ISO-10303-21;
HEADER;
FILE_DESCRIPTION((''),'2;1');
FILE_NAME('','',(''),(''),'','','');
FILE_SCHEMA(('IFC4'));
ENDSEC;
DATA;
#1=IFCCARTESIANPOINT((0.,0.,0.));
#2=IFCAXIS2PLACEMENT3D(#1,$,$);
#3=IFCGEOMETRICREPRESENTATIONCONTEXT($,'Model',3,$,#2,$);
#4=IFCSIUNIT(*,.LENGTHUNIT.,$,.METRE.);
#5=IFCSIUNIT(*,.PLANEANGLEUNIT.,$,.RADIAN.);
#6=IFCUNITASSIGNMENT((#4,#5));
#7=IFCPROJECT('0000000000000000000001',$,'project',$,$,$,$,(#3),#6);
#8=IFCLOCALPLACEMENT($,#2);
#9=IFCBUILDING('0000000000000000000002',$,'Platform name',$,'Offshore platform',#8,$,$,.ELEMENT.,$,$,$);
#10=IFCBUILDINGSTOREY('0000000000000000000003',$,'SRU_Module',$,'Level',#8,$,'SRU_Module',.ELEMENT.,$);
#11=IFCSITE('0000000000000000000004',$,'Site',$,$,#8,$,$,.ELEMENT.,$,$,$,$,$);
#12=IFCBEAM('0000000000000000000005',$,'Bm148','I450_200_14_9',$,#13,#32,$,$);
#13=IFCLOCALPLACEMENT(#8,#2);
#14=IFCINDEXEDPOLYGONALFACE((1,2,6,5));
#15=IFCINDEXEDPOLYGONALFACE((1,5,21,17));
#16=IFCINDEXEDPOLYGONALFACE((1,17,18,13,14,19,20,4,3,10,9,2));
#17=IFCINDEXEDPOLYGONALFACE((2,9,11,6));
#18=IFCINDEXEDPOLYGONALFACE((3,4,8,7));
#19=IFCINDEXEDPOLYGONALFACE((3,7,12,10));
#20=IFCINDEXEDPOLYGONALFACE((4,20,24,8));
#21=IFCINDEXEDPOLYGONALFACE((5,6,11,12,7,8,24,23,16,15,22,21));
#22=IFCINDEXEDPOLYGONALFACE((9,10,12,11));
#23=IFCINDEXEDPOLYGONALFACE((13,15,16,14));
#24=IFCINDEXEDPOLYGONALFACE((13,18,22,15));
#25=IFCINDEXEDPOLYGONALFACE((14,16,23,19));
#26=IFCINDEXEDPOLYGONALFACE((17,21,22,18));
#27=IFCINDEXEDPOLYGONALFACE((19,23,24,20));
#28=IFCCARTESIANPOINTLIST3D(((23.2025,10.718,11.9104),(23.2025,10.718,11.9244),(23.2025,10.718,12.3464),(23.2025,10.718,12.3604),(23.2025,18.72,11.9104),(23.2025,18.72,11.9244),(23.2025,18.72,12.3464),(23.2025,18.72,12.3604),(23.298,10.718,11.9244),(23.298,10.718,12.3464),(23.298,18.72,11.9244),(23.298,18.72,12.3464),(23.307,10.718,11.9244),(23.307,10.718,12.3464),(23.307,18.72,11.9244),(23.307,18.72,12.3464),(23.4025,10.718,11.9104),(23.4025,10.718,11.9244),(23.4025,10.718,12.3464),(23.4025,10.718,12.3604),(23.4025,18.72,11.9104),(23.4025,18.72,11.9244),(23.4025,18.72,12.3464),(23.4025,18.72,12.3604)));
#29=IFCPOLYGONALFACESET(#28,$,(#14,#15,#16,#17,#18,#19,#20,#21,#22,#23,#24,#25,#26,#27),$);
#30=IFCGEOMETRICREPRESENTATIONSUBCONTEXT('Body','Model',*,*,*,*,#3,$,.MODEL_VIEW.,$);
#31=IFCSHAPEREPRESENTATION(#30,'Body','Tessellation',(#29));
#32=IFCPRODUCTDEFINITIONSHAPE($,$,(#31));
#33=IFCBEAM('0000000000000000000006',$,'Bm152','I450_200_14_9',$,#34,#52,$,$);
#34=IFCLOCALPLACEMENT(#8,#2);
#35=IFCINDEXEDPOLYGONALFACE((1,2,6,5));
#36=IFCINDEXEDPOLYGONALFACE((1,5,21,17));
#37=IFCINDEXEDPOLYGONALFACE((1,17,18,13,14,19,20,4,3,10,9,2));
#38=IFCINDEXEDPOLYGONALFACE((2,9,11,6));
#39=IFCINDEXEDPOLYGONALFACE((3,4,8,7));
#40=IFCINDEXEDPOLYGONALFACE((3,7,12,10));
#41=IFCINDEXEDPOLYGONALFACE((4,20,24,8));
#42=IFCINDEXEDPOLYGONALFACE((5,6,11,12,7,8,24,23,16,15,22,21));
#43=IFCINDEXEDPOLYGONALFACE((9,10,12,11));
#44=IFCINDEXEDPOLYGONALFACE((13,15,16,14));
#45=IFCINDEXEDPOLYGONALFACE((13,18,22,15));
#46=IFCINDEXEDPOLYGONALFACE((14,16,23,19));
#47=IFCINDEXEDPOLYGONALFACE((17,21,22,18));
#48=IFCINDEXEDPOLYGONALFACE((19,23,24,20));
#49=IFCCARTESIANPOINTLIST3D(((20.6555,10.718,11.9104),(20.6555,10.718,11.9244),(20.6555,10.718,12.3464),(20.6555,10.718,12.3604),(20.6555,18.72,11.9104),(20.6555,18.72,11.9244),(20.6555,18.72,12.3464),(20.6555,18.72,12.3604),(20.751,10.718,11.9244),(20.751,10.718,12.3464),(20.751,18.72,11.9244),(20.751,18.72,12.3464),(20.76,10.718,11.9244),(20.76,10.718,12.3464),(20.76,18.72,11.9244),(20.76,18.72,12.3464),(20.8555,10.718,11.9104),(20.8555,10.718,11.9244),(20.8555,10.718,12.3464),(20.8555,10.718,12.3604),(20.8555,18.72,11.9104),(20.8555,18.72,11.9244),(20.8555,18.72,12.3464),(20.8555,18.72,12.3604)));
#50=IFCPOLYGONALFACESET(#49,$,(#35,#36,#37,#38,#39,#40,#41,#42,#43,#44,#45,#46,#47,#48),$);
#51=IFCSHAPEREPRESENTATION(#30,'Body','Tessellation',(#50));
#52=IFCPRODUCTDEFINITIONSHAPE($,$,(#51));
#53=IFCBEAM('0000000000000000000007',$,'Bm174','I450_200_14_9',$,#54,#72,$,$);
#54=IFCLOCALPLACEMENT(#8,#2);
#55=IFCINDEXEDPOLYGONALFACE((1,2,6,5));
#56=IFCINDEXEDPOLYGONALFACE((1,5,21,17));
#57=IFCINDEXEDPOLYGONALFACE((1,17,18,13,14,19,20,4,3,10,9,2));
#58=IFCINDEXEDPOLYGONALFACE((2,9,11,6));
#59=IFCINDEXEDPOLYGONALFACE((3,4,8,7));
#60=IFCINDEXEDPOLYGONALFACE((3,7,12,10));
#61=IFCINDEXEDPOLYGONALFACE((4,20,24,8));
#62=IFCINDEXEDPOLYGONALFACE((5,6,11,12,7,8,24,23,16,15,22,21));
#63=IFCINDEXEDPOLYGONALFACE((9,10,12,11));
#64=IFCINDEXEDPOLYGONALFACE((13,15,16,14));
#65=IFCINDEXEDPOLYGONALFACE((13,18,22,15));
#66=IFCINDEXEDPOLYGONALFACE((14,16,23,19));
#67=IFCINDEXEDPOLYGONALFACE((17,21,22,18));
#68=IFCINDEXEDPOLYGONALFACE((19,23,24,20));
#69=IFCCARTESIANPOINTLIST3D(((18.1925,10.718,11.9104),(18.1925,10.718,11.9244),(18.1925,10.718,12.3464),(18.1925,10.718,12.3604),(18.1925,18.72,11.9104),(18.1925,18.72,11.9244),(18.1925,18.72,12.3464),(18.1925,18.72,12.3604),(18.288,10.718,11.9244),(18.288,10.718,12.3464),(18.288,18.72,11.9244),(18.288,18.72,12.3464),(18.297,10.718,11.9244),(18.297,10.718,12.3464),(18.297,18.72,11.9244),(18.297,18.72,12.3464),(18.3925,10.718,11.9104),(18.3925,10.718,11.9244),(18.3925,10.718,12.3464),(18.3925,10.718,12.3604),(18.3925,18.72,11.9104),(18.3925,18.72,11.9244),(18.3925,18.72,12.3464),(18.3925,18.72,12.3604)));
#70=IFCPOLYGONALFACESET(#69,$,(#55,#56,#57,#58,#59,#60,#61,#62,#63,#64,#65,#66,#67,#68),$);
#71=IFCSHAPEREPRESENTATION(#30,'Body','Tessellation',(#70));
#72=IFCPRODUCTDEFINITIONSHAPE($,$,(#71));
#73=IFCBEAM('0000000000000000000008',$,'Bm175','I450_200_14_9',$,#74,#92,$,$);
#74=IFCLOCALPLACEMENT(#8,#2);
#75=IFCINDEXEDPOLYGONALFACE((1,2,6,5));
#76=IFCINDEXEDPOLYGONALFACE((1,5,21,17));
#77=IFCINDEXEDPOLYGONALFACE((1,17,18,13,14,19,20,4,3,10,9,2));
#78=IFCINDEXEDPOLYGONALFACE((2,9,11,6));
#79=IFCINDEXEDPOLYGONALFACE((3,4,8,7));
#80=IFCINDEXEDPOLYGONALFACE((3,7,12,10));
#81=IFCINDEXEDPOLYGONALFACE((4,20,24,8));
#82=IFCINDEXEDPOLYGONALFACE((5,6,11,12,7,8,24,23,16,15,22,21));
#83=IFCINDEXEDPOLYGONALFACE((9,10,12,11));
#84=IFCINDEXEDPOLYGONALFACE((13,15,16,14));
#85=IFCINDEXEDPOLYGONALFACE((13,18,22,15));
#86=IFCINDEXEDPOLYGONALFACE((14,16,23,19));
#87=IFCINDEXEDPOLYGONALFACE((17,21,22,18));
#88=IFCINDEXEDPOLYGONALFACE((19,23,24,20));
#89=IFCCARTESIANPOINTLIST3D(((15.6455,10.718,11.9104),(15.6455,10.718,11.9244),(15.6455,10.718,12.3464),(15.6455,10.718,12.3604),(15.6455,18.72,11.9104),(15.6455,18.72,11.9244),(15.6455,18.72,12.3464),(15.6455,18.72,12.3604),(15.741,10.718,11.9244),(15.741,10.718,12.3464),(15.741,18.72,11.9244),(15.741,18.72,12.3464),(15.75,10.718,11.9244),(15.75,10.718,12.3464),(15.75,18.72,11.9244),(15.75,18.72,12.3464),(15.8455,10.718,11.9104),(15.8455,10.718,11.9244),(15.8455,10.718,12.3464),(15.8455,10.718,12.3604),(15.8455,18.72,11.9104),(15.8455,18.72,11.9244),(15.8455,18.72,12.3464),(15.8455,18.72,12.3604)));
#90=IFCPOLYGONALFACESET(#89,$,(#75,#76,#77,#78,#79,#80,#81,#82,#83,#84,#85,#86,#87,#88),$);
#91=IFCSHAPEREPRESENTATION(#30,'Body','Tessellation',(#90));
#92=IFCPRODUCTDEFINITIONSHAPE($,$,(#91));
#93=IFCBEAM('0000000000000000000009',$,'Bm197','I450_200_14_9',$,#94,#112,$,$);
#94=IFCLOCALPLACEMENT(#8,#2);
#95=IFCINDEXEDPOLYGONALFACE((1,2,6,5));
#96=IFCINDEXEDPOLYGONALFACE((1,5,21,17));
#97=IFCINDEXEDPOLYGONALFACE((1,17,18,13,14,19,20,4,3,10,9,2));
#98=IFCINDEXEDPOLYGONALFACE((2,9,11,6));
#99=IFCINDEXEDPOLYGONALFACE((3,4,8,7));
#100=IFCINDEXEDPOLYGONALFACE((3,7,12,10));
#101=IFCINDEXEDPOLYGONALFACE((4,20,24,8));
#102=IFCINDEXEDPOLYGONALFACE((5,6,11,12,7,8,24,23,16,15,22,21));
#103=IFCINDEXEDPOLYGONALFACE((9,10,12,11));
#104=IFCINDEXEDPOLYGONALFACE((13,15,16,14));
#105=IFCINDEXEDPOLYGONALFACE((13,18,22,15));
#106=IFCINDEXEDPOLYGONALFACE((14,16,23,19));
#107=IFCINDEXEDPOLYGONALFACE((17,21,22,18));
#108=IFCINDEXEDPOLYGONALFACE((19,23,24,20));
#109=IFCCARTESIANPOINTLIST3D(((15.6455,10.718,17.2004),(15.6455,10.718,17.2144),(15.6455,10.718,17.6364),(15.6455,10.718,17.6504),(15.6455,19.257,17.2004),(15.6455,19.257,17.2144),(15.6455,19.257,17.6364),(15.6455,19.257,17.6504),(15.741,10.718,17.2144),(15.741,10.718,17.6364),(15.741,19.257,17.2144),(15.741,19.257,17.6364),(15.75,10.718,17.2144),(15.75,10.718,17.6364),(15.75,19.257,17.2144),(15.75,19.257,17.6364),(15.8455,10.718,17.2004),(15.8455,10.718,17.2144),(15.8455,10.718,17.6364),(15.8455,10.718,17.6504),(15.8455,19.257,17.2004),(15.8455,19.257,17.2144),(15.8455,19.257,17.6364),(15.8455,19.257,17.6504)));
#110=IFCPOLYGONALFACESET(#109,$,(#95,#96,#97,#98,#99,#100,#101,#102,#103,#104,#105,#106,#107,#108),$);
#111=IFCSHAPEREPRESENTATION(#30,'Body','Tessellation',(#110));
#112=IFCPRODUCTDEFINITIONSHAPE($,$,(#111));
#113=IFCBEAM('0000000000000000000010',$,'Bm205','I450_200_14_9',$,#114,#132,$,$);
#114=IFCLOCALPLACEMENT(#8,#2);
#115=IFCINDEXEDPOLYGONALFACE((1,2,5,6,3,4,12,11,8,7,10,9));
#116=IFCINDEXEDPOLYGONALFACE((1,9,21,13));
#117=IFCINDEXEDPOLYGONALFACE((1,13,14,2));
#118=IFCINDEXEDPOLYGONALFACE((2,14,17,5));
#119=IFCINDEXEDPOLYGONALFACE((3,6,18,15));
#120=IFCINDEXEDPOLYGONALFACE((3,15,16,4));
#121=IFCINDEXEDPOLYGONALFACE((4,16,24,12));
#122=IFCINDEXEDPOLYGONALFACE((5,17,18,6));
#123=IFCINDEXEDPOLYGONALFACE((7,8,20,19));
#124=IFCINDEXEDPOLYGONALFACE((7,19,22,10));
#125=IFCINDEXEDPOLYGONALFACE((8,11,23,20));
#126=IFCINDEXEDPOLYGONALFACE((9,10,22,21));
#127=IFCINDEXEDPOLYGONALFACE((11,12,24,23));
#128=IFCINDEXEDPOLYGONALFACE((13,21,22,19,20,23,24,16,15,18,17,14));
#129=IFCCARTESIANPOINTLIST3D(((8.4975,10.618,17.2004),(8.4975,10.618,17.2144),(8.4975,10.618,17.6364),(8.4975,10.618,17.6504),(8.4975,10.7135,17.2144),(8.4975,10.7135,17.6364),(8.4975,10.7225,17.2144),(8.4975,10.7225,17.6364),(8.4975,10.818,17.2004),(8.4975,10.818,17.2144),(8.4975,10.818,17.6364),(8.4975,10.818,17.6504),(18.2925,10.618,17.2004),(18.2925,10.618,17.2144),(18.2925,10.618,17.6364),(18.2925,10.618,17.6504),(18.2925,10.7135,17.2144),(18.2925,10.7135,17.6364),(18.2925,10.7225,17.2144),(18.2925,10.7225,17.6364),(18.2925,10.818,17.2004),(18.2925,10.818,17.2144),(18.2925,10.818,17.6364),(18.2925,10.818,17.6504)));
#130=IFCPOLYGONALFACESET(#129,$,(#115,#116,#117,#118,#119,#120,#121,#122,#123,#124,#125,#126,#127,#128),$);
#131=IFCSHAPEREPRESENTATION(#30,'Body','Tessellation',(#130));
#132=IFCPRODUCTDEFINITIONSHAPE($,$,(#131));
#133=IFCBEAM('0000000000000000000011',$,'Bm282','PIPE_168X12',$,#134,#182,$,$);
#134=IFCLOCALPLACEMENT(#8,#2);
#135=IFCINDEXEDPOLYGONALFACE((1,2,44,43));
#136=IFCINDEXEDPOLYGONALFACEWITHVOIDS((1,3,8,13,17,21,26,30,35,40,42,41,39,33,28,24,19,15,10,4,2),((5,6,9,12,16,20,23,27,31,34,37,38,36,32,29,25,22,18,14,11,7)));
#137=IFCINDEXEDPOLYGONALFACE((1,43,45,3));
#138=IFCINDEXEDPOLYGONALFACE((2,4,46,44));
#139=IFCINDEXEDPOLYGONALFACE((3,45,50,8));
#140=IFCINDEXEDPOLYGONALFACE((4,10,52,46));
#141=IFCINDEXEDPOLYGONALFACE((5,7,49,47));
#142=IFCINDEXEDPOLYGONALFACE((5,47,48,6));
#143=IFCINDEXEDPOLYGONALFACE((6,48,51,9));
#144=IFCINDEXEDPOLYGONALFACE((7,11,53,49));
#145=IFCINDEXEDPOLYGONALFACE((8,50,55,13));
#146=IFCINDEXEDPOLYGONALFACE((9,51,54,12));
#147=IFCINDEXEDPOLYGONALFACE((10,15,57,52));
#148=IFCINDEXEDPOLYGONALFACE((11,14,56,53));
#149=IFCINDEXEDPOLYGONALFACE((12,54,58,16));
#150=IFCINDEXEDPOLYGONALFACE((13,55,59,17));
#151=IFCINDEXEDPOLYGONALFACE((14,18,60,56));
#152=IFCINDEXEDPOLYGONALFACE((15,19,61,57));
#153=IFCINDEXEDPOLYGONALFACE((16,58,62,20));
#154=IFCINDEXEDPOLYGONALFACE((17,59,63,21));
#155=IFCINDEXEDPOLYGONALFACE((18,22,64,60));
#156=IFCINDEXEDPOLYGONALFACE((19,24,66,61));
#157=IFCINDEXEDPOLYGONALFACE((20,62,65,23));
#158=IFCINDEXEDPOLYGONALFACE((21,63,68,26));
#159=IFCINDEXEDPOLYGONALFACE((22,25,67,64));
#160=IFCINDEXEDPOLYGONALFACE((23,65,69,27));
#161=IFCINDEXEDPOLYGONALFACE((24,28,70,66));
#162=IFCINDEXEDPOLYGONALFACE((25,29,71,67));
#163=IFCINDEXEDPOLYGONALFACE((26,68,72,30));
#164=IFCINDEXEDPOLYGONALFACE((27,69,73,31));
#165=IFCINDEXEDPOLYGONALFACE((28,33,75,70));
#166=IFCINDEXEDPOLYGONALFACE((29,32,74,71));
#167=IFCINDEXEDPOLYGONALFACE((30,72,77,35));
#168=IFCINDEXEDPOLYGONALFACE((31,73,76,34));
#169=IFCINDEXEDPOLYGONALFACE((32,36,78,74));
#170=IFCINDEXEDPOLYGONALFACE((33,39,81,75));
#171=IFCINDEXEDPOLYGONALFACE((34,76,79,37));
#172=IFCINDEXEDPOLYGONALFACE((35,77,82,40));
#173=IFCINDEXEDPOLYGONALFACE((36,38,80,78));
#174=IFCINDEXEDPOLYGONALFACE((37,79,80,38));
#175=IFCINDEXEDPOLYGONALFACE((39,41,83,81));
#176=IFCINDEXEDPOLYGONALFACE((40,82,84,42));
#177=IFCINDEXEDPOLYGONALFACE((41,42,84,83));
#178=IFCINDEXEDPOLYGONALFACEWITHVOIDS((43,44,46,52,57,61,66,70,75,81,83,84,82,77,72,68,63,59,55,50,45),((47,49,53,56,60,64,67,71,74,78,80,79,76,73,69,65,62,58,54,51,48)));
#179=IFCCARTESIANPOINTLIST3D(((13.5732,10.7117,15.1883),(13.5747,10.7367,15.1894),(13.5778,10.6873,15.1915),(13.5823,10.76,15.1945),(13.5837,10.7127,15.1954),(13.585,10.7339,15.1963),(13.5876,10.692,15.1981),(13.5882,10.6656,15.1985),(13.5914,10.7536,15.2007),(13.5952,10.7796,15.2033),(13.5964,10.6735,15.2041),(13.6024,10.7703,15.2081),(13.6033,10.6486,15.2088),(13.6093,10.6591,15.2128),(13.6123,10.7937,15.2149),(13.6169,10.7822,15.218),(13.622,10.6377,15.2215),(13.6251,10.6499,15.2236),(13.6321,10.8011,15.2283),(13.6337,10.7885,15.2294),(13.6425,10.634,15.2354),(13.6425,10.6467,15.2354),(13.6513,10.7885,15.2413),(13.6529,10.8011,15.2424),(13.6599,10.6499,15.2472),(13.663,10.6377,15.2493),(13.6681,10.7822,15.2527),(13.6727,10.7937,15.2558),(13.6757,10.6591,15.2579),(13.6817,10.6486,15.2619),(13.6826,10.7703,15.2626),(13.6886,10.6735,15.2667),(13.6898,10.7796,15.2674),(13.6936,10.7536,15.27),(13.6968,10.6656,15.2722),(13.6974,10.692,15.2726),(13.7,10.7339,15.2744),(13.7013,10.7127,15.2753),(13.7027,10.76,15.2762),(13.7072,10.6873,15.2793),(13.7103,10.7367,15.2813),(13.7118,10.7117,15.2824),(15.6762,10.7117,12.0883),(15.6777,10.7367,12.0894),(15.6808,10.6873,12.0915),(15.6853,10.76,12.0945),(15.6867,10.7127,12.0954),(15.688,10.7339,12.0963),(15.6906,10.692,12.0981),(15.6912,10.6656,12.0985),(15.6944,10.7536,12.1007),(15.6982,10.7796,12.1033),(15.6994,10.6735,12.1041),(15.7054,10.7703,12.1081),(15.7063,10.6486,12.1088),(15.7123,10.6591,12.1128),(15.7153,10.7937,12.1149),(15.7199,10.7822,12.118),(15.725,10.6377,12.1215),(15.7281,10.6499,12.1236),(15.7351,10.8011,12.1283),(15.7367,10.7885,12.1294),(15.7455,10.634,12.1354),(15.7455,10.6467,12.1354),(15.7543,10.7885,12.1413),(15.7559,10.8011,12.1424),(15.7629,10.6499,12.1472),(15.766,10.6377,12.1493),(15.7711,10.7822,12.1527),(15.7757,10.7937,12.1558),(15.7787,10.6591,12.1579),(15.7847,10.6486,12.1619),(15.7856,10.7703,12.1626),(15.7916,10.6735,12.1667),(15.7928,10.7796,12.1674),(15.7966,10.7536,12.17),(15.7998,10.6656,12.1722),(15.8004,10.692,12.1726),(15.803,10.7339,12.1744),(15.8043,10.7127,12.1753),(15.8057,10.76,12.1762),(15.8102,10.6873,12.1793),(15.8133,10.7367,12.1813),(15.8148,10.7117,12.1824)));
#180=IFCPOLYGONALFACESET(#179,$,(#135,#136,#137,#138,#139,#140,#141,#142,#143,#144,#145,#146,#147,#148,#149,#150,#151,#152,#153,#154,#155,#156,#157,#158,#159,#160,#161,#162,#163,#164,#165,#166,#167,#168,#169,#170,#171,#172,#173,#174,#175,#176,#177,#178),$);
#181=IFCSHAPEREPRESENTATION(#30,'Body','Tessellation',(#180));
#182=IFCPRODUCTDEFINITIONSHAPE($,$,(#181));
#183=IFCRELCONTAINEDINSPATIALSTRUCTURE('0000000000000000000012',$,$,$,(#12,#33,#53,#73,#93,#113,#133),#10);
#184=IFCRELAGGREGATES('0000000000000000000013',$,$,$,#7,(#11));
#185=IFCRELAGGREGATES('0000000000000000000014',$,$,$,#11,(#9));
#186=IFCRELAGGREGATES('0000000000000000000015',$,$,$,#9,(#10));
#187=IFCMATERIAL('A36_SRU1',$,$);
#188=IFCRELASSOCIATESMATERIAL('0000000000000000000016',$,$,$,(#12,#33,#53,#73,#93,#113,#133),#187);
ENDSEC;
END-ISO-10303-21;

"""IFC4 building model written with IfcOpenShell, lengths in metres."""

from ifc_helpers import new_model, si_unit, frame, origin, origin_2d, place, context, subcontext, project, spatial, hollow_circle, i_section, extrude, source, transform, mapped, material, element, save


model = new_model("IFC4")

# Units and contexts
model_context = context("Model", 3, world=origin())
body_context = subcontext(model_context, "Body", "Model", "MODEL_VIEW")
ifc_project = project(units=[si_unit("LENGTHUNIT", "METRE"), si_unit("PLANEANGLEUNIT", "RADIAN")], contexts=[model_context])

# Site, building, storey
placement_1 = place(None, origin())
site = spatial("IfcSite", under=ifc_project, at=placement_1, Name="Site", CompositionType="ELEMENT")
building = spatial("IfcBuilding", under=site, at=placement_1, Name="Platform name", ObjectType="Offshore platform", CompositionType="ELEMENT")
storey = spatial("IfcBuildingStorey", under=building, at=placement_1, Name="SRU_Module", ObjectType="Level", LongName="SRU_Module", CompositionType="ELEMENT")

# Beams
ifc_material = material(Name="A36_SRU1")
shared_shape_1 = source(origin(), body_context, "Body", "SweptSolid", [
    extrude(i_section(OverallWidth=0.2, OverallDepth=0.45, WebThickness=0.009, FlangeThickness=0.014, FilletRadius=0.0, at=origin_2d()), frame((0.0, 0.0, 0.0), z_axis=(0.0, 1.0, 0.0), x_axis=(-1.0, 0.0, 0.0)), (0.0, 0.0, 1.0), 8.002),
])
placement_2 = place(None, origin())
placement_3 = place(placement_2, origin())
placement_4 = place(placement_3, origin())
beam_1_placement = place(placement_4, frame((23.3025, 10.718, 12.1354)))
element("IfcBeam", 1, at=beam_1_placement, inside=storey, material=ifc_material, Name="Bm148", Description="I450_200_14_9", context=body_context, shape_type="MappedRepresentation", body=[
    mapped(shared_shape_1, transform((0.0, 0.0, 0.0), scale=1.0)),
])
shared_shape_2 = source(origin(), body_context, "Body", "SweptSolid", [
    extrude(i_section(OverallWidth=0.2, OverallDepth=0.45, WebThickness=0.009, FlangeThickness=0.014, FilletRadius=0.0, at=origin_2d()), frame((0.0, 0.0, 0.0), z_axis=(0.0, 1.0, 0.0), x_axis=(-1.0, 0.0, 0.0)), (0.0, 0.0, 1.0), 8.002),
])
placement_5 = place(None, origin())
placement_6 = place(placement_5, origin())
placement_7 = place(placement_6, origin())
beam_2_placement = place(placement_7, frame((20.7555, 10.718, 12.1354)))
element("IfcBeam", 2, at=beam_2_placement, inside=storey, material=ifc_material, Name="Bm152", Description="I450_200_14_9", context=body_context, shape_type="MappedRepresentation", body=[
    mapped(shared_shape_2, transform((0.0, 0.0, 0.0), scale=1.0)),
])
shared_shape_3 = source(origin(), body_context, "Body", "SweptSolid", [
    extrude(i_section(OverallWidth=0.2, OverallDepth=0.45, WebThickness=0.009, FlangeThickness=0.014, FilletRadius=0.0, at=origin_2d()), frame((0.0, 0.0, 0.0), z_axis=(0.0, 1.0, 0.0), x_axis=(-1.0, 0.0, 0.0)), (0.0, 0.0, 1.0), 8.002),
])
placement_8 = place(None, origin())
placement_9 = place(placement_8, origin())
placement_10 = place(placement_9, origin())
beam_3_placement = place(placement_10, frame((18.2925, 10.718, 12.1354)))
element("IfcBeam", 3, at=beam_3_placement, inside=storey, material=ifc_material, Name="Bm174", Description="I450_200_14_9", context=body_context, shape_type="MappedRepresentation", body=[
    mapped(shared_shape_3, transform((0.0, 0.0, 0.0), scale=1.0)),
])
shared_shape_4 = source(origin(), body_context, "Body", "SweptSolid", [
    extrude(i_section(OverallWidth=0.2, OverallDepth=0.45, WebThickness=0.009, FlangeThickness=0.014, FilletRadius=0.0, at=origin_2d()), frame((0.0, 0.0, 0.0), z_axis=(0.0, 1.0, 0.0), x_axis=(-1.0, 0.0, 0.0)), (0.0, 0.0, 1.0), 8.002),
])
placement_11 = place(None, origin())
placement_12 = place(placement_11, origin())
placement_13 = place(placement_12, origin())
beam_4_placement = place(placement_13, frame((15.7455, 10.718, 12.1354)))
element("IfcBeam", 4, at=beam_4_placement, inside=storey, material=ifc_material, Name="Bm175", Description="I450_200_14_9", context=body_context, shape_type="MappedRepresentation", body=[
    mapped(shared_shape_4, transform((0.0, 0.0, 0.0), scale=1.0)),
])
shared_shape_5 = source(origin(), body_context, "Body", "SweptSolid", [
    extrude(i_section(OverallWidth=0.2, OverallDepth=0.45, WebThickness=0.009, FlangeThickness=0.014, FilletRadius=0.0, at=origin_2d()), frame((0.0, 0.0, 0.0), z_axis=(0.0, 1.0, 0.0), x_axis=(-1.0, 0.0, 0.0)), (0.0, 0.0, 1.0), 8.539),
])
placement_14 = place(None, origin())
placement_15 = place(placement_14, origin())
placement_16 = place(placement_15, origin())
beam_5_placement = place(placement_16, frame((15.7455, 10.718, 17.4254)))
element("IfcBeam", 5, at=beam_5_placement, inside=storey, material=ifc_material, Name="Bm197", Description="I450_200_14_9", context=body_context, shape_type="MappedRepresentation", body=[
    mapped(shared_shape_5, transform((0.0, 0.0, 0.0), scale=1.0)),
])
shared_shape_6 = source(origin(), body_context, "Body", "SweptSolid", [
    extrude(i_section(OverallWidth=0.2, OverallDepth=0.45, WebThickness=0.009, FlangeThickness=0.014, FilletRadius=0.0, at=origin_2d()), frame((0.0, 0.0, 0.0), z_axis=(-1.0, 0.0, 0.0), x_axis=(0.0, -1.0, 0.0)), (0.0, 0.0, 1.0), 9.795),
])
placement_17 = place(None, origin())
placement_18 = place(placement_17, origin())
placement_19 = place(placement_18, origin())
beam_6_placement = place(placement_19, frame((18.2925, 10.718, 17.4254)))
element("IfcBeam", 6, at=beam_6_placement, inside=storey, material=ifc_material, Name="Bm205", Description="I450_200_14_9", context=body_context, shape_type="MappedRepresentation", body=[
    mapped(shared_shape_6, transform((0.0, 0.0, 0.0), scale=1.0)),
])
shared_shape_7 = source(origin(), body_context, "Body", "SweptSolid", [
    extrude(hollow_circle(Radius=0.084, WallThickness=0.0127, at=origin_2d()), frame((0.0, 0.0, 0.0), z_axis=(-0.561397, 0.0, 0.827547), x_axis=(0.0, -1.0, 0.0)), (0.0, 0.0, 1.0), 3.746),
])
placement_20 = place(None, origin())
placement_21 = place(placement_20, origin())
placement_22 = place(placement_21, origin())
beam_7_placement = place(placement_22, frame((15.7455, 10.718, 12.1354)))
element("IfcBeam", 7, at=beam_7_placement, inside=storey, material=ifc_material, Name="Bm282", Description="PIPE_168X12", context=body_context, shape_type="MappedRepresentation", body=[
    mapped(shared_shape_7, transform((0.0, 0.0, 0.0), scale=1.0)),
])

save(model, "model.ifc")
